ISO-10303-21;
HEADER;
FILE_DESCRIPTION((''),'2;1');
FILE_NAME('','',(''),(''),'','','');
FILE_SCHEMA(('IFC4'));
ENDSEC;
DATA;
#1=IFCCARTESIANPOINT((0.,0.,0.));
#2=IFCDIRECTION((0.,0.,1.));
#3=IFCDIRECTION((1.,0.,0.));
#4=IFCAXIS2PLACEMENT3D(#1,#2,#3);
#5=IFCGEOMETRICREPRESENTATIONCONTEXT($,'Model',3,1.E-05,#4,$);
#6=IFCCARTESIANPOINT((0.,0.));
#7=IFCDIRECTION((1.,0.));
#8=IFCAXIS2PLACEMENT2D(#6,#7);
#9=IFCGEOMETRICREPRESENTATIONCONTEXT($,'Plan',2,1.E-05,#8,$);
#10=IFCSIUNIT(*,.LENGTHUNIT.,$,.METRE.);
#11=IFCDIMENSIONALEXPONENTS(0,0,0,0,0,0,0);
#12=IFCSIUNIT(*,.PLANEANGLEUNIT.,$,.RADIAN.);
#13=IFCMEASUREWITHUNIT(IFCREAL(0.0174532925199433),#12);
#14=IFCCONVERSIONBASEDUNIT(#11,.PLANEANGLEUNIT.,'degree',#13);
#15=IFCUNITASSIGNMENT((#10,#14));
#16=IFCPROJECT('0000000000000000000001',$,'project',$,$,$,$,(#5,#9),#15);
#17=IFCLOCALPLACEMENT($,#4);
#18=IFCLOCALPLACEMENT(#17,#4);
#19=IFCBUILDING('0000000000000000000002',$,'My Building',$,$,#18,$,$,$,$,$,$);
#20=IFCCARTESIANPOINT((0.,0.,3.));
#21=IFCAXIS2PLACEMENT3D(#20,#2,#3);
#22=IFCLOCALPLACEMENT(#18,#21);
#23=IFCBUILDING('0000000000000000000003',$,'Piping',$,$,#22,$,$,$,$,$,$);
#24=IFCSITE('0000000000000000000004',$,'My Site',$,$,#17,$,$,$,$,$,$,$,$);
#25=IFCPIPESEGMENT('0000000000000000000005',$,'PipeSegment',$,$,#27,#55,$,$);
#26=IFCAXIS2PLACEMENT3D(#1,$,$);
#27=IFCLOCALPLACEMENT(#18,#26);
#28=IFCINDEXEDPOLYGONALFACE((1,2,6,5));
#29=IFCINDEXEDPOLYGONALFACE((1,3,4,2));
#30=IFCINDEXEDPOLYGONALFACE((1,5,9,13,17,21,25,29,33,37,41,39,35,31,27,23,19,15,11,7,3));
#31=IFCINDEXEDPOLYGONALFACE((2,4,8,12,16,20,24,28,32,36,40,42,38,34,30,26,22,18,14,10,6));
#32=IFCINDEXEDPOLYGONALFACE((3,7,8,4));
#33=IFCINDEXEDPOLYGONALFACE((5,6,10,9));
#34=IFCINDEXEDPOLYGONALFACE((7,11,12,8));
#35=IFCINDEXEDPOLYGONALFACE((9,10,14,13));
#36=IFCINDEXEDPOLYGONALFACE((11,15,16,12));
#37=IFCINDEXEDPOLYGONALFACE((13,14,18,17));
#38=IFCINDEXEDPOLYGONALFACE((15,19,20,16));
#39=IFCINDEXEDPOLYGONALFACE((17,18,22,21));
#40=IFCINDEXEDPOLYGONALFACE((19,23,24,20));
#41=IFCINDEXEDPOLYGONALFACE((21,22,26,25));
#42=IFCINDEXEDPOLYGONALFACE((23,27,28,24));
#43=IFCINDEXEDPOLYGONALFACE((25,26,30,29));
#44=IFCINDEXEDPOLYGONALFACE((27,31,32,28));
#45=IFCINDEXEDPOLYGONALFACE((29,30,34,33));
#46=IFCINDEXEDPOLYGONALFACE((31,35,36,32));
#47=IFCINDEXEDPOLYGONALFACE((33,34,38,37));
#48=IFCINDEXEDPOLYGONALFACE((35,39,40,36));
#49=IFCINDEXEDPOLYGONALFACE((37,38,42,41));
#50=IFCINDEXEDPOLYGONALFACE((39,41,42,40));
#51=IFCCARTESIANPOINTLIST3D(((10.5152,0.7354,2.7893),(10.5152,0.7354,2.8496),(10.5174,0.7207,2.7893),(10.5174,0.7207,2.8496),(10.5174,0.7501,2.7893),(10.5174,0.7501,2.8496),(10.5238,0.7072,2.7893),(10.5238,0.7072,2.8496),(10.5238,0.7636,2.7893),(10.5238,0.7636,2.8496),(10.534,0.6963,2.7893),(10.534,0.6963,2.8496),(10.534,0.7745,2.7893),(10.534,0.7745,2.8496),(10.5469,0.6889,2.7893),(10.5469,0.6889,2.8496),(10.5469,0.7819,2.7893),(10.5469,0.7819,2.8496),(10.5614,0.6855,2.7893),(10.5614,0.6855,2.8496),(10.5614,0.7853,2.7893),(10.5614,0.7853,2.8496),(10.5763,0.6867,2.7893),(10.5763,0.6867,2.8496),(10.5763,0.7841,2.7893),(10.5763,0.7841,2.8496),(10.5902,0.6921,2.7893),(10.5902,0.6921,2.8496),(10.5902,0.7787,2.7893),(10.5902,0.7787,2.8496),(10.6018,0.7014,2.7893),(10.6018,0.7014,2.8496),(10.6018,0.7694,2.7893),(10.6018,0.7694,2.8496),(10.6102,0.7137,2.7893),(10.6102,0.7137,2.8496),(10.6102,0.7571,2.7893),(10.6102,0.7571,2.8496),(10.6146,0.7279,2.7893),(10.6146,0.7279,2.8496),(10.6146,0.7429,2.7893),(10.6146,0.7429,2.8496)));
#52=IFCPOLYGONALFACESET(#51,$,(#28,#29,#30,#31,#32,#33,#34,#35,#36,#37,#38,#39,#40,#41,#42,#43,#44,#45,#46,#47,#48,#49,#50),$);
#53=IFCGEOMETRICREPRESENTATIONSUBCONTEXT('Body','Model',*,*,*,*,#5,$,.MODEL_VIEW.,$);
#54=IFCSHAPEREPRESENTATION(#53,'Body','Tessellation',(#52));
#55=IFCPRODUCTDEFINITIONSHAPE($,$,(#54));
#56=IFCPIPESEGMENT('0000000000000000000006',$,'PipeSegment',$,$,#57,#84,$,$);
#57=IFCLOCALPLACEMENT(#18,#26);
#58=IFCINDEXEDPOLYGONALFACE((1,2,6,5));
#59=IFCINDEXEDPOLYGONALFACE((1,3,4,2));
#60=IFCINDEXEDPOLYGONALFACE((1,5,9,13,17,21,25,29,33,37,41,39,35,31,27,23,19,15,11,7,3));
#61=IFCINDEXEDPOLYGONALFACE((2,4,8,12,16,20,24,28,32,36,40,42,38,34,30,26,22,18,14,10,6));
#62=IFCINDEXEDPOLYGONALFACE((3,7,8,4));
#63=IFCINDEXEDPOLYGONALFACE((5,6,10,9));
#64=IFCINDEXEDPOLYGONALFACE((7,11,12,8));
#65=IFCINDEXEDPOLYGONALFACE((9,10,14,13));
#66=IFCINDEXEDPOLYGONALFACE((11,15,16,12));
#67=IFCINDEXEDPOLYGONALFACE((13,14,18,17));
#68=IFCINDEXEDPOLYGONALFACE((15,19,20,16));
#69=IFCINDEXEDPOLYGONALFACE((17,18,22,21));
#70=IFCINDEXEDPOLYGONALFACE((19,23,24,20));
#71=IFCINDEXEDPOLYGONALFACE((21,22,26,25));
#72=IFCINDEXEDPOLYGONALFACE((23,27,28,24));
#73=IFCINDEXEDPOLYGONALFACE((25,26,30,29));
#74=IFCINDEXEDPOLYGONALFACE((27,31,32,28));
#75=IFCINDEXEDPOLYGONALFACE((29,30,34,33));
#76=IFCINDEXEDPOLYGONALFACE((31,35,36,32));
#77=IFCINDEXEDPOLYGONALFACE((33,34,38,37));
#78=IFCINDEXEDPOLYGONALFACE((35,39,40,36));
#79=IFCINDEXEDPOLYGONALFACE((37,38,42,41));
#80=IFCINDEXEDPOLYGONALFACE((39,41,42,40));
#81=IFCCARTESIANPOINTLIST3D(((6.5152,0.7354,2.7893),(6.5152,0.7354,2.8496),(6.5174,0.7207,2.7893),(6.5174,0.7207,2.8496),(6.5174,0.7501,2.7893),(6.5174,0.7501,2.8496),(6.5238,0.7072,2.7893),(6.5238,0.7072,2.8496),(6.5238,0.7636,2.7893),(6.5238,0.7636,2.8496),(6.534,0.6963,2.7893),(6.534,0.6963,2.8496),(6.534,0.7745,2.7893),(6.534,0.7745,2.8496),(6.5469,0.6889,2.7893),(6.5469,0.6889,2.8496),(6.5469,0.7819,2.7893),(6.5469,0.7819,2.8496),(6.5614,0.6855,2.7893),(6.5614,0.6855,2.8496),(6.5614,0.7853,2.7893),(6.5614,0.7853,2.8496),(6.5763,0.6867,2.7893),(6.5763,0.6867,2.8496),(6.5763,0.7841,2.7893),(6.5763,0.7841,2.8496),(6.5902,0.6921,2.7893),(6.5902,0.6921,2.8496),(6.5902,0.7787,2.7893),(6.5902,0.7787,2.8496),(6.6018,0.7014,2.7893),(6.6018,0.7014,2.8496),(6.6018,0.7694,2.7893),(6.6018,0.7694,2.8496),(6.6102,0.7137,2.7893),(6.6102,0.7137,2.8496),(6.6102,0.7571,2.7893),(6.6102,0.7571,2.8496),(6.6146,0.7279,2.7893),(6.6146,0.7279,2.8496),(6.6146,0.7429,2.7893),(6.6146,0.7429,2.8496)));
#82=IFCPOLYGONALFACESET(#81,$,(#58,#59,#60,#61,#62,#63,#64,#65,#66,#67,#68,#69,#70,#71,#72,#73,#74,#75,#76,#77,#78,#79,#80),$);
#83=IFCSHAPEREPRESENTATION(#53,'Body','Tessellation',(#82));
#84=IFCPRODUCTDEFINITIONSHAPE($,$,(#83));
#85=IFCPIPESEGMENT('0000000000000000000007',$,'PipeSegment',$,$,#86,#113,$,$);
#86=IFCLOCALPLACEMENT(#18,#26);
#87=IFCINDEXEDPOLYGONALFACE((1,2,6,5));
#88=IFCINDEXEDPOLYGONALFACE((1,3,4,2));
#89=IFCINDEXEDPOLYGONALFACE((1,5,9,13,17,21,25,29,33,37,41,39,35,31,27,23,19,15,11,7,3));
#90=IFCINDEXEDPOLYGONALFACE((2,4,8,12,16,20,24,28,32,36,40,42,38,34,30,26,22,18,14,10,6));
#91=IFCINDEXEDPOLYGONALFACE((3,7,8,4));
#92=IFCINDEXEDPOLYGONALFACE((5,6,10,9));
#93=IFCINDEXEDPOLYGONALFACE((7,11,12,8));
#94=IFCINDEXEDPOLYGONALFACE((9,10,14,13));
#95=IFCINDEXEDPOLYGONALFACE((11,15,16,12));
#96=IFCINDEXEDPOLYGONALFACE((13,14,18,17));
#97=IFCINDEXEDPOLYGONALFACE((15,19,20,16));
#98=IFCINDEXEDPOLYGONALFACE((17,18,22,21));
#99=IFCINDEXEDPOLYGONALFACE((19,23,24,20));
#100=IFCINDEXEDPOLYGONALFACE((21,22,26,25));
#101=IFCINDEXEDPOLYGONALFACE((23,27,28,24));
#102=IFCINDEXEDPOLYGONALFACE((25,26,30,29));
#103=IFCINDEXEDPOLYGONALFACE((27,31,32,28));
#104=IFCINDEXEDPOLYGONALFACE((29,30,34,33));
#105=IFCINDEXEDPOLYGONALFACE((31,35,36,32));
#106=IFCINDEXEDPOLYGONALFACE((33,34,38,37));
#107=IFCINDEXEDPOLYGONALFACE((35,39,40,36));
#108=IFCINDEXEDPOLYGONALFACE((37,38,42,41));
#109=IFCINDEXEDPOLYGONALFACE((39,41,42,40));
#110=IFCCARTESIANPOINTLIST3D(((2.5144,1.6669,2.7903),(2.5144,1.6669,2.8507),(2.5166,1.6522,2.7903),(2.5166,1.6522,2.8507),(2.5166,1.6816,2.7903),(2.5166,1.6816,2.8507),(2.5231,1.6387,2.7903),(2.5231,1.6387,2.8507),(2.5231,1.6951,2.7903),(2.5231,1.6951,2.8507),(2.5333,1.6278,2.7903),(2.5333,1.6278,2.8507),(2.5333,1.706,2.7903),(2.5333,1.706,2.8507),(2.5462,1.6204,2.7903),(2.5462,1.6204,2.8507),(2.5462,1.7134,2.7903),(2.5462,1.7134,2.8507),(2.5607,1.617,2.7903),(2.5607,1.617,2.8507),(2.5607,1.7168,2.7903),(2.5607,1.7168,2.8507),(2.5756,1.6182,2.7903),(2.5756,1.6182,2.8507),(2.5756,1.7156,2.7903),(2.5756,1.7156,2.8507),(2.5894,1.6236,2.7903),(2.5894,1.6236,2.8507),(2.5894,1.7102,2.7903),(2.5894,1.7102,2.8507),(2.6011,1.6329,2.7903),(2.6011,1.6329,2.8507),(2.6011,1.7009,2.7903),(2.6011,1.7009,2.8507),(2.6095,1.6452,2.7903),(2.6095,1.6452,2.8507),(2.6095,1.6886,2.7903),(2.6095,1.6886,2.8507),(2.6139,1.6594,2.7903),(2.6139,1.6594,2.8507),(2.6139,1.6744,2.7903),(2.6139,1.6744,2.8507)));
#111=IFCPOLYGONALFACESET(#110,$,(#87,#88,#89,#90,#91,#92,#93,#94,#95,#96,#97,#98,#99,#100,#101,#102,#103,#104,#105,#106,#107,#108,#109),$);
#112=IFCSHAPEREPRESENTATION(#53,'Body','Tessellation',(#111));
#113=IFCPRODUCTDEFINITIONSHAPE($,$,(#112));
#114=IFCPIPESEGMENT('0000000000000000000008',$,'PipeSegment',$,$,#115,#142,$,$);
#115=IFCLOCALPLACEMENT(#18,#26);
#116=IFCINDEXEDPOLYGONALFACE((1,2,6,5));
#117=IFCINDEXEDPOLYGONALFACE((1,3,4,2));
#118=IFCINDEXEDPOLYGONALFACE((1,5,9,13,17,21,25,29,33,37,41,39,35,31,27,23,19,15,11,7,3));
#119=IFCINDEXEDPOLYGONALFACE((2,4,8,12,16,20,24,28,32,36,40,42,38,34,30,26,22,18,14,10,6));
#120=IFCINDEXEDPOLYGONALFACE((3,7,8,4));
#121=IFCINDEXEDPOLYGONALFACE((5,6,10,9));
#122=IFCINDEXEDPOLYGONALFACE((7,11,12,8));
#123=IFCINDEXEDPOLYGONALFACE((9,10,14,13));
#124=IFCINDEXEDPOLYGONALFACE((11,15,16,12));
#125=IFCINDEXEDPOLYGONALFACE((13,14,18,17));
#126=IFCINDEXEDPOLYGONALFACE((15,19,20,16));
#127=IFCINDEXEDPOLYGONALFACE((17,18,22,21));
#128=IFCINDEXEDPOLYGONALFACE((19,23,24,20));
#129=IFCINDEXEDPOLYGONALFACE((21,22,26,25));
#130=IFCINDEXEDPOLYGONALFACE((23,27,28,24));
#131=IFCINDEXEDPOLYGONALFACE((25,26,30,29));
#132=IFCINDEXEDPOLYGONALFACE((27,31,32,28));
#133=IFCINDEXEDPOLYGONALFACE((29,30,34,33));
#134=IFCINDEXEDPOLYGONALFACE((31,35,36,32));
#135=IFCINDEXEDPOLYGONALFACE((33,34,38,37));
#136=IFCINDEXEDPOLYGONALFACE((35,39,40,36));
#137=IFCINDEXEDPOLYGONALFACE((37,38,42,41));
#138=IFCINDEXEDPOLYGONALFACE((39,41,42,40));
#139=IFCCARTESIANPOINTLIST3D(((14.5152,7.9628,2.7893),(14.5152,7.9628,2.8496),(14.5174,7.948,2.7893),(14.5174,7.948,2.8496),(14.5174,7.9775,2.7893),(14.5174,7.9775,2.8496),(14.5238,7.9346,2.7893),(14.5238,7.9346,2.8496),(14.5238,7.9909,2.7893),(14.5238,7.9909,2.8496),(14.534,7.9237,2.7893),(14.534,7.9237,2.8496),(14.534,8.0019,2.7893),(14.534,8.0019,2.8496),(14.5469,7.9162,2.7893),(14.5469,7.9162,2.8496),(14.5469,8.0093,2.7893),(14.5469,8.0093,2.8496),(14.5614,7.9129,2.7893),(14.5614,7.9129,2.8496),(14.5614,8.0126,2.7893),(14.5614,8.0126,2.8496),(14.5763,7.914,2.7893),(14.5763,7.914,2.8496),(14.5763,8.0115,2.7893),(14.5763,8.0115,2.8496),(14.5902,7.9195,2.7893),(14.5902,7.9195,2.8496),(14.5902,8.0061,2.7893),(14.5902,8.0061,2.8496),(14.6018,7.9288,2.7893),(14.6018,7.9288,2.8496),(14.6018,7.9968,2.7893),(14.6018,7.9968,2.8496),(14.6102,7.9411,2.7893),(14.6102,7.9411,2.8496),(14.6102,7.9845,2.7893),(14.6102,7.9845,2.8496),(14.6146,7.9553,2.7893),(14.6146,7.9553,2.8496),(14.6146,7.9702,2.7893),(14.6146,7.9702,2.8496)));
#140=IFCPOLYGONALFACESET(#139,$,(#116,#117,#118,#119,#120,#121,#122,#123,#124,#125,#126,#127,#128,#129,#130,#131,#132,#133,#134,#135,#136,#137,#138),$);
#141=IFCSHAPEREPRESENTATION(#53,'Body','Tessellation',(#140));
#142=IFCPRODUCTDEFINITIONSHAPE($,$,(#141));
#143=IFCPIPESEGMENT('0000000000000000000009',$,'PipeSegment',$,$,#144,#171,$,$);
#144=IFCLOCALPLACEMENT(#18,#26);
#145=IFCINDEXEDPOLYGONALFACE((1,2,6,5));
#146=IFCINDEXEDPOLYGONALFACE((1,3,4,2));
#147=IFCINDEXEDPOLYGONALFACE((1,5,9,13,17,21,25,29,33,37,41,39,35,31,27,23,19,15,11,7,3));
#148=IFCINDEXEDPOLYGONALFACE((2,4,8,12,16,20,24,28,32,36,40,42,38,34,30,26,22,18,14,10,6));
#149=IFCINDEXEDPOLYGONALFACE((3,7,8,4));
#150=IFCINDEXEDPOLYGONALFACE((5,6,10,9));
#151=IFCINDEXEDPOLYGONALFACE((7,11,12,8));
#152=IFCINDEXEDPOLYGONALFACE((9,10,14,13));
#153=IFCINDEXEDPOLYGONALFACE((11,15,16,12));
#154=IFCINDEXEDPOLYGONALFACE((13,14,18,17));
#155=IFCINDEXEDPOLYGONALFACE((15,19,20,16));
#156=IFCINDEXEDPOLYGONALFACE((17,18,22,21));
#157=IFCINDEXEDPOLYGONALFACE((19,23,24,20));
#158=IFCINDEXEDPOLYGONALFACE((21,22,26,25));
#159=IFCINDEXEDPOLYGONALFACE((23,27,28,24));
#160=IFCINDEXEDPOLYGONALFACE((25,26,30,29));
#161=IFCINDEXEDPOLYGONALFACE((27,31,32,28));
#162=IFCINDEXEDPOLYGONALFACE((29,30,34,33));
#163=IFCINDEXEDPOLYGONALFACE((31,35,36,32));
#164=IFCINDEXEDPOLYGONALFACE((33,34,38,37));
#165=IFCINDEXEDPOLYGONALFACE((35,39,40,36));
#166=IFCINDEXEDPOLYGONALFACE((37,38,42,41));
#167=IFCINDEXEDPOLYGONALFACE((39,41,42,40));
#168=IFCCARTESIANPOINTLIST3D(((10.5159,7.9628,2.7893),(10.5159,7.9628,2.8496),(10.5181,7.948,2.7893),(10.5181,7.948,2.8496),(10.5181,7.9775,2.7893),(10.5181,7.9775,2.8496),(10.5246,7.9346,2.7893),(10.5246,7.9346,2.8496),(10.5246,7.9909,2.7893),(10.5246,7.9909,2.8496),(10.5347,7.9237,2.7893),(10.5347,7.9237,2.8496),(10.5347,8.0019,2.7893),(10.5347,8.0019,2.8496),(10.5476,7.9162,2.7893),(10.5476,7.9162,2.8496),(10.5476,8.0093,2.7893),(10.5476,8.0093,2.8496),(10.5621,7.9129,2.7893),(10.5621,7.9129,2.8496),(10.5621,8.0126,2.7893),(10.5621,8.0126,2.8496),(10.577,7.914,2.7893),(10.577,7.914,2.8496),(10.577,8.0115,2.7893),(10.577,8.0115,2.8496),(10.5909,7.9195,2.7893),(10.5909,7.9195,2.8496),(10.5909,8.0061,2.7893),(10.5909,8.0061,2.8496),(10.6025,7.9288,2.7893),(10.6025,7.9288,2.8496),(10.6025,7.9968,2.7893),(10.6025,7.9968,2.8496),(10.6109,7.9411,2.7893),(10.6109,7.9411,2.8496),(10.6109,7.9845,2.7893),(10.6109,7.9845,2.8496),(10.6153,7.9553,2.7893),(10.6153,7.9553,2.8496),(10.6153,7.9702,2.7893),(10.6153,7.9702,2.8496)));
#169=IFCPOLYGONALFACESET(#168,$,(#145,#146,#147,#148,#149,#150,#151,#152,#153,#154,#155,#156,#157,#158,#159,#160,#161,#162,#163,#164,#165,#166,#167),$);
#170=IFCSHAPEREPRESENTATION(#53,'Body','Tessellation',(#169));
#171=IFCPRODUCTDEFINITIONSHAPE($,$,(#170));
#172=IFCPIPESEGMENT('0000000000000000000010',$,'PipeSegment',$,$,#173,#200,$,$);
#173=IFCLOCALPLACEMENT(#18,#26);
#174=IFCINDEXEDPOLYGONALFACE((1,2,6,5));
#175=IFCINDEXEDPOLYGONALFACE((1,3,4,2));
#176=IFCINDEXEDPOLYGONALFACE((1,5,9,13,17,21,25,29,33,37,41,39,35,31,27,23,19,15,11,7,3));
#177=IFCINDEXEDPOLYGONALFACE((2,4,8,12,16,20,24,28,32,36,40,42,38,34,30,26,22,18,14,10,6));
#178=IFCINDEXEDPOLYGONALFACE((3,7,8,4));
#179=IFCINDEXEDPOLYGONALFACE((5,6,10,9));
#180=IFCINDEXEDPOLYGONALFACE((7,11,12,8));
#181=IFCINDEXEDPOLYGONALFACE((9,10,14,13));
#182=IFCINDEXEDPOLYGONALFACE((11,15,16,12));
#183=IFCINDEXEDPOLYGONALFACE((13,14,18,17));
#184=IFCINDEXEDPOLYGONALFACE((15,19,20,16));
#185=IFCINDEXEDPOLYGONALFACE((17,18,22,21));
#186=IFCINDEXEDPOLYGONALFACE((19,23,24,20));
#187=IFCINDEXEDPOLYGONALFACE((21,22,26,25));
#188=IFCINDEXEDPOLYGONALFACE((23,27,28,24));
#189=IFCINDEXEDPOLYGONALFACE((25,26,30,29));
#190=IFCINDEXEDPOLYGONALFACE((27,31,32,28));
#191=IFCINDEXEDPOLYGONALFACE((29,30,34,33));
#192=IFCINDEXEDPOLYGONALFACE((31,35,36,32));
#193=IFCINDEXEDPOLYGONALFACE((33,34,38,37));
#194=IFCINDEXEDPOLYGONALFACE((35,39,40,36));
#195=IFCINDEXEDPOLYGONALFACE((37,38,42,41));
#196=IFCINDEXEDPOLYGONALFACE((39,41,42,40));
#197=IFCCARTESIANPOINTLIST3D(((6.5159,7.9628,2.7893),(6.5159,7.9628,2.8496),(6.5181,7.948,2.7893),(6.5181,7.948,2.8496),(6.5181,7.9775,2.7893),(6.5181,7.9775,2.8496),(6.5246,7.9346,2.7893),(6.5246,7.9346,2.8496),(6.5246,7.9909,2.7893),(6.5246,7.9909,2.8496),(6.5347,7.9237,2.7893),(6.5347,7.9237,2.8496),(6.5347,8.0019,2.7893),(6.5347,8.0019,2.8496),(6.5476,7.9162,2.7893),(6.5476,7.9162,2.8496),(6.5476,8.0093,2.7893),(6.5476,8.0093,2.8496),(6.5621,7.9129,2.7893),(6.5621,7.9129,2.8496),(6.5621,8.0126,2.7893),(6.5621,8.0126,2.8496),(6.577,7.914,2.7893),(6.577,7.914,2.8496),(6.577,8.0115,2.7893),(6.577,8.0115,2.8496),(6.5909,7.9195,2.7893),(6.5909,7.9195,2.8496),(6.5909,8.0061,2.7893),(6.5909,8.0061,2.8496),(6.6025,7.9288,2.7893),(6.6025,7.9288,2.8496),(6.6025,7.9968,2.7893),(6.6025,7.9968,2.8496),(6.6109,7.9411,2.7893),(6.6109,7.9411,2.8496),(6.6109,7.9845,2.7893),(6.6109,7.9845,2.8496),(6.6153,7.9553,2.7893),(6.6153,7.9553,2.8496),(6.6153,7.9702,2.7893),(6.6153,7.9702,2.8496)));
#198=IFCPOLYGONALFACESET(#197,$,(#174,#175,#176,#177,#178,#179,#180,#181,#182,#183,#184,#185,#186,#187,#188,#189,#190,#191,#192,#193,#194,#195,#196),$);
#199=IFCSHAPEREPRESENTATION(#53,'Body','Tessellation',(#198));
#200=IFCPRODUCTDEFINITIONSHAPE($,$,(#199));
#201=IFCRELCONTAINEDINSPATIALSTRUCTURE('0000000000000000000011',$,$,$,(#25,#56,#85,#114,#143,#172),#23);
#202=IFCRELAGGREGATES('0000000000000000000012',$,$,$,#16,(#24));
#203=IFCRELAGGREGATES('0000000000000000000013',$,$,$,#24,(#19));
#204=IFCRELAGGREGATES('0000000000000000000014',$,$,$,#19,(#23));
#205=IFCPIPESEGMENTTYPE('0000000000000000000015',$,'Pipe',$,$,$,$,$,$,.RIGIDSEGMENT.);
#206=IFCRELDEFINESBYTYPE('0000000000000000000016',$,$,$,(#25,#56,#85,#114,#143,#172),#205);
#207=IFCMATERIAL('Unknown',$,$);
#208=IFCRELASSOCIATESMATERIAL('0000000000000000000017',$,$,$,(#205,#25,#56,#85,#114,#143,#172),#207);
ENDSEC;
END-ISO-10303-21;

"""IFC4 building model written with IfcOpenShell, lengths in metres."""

from ifc_helpers import new_model, entity, si_unit, converted_unit, frame, origin_with_axes, origin_2d_with_axis, place, context, subcontext, project, spatial, circle, extrude, material, material_profile, profile_set, profile_usage, type_object, element, save


model = new_model("IFC4")

# Units and contexts
model_context = context("Model", 3, precision=1e-05, world=origin_with_axes())
plan_context = context("Plan", 2, precision=1e-05, world=origin_2d_with_axis())
body_context = subcontext(model_context, "Body", "Model", "MODEL_VIEW")
ifc_project = project(units=[si_unit("LENGTHUNIT", "METRE"), converted_unit("PLANEANGLEUNIT", "degree", entity("IfcReal", 0.0174532925199433), si_unit("PLANEANGLEUNIT", "RADIAN"), dimensions=[0, 0, 0, 0, 0, 0, 0])], contexts=[model_context, plan_context])

# Site, buildings
site_placement = place(None, origin_with_axes())
site = spatial("IfcSite", under=ifc_project, at=site_placement, Name="My Site")
building_1_placement = place(site_placement, origin_with_axes())
building_1 = spatial("IfcBuilding", under=site, at=building_1_placement, Name="My Building")
building_2_placement = place(building_1_placement, frame((0.0, 0.0, 3.0), z_axis=(0.0, 0.0, 1.0), x_axis=(1.0, 0.0, 0.0)))
building_2 = spatial("IfcBuilding", under=building_1, at=building_2_placement, Name="Piping")

# Pipe segments
ifc_material = material(Name="Unknown")
ifc_material_profile_1 = material_profile(ifc_material, circle(Radius=0.05))
ifc_profile_set_1 = profile_set([ifc_material_profile_1])
pipe_segment_type = type_object("IfcPipeSegmentType", Name="Pipe", PredefinedType="RIGIDSEGMENT", material=ifc_profile_set_1)
ifc_profile_usage_1 = profile_usage(ifc_profile_set_1, cardinal=5)
pipe_segment_1_placement = place(building_2_placement, frame((10.5652, 0.7354, -0.1504), z_axis=(0.0, 0.0, -1.0), x_axis=(-1.0, 0.0, 0.0)))
element("IfcPipeSegment", 1, at=pipe_segment_1_placement, inside=building_2, type_object=pipe_segment_type, material=ifc_profile_usage_1, Name="PipeSegment", context=body_context, shape_type="SweptSolid", body=[
    extrude(circle(Radius=0.05), origin_with_axes(), (0.0, 0.0, 1.0), 0.0604),
])
ifc_profile_usage_2 = profile_usage(ifc_profile_set_1, cardinal=5)
pipe_segment_2_placement = place(building_2_placement, frame((6.5652, 0.7354, -0.1504), z_axis=(0.0, 0.0, -1.0), x_axis=(-1.0, 0.0, 0.0)))
element("IfcPipeSegment", 2, at=pipe_segment_2_placement, inside=building_2, type_object=pipe_segment_type, material=ifc_profile_usage_2, Name="PipeSegment", context=body_context, shape_type="SweptSolid", body=[
    extrude(circle(Radius=0.05), origin_with_axes(), (0.0, 0.0, 1.0), 0.0604),
])
ifc_profile_usage_3 = profile_usage(ifc_profile_set_1, cardinal=5)
pipe_segment_3_placement = place(building_2_placement, frame((2.5644, 1.6669, -0.1493), z_axis=(0.0, 0.0, -1.0), x_axis=(-1.0, 0.0, 0.0)))
element("IfcPipeSegment", 3, at=pipe_segment_3_placement, inside=building_2, type_object=pipe_segment_type, material=ifc_profile_usage_3, Name="PipeSegment", context=body_context, shape_type="SweptSolid", body=[
    extrude(circle(Radius=0.05), origin_with_axes(), (0.0, 0.0, 1.0), 0.0604),
])
ifc_profile_usage_4 = profile_usage(ifc_profile_set_1, cardinal=5)
pipe_segment_4_placement = place(building_2_placement, frame((14.5652, 7.9628, -0.1504), z_axis=(0.0, 0.0, -1.0), x_axis=(-1.0, 0.0, 0.0)))
element("IfcPipeSegment", 4, at=pipe_segment_4_placement, inside=building_2, type_object=pipe_segment_type, material=ifc_profile_usage_4, Name="PipeSegment", context=body_context, shape_type="SweptSolid", body=[
    extrude(circle(Radius=0.05), origin_with_axes(), (0.0, 0.0, 1.0), 0.0604),
])
ifc_profile_usage_5 = profile_usage(ifc_profile_set_1, cardinal=5)
pipe_segment_5_placement = place(building_2_placement, frame((10.5659, 7.9628, -0.1504), z_axis=(0.0, 0.0, -1.0), x_axis=(-1.0, 0.0, 0.0)))
element("IfcPipeSegment", 5, at=pipe_segment_5_placement, inside=building_2, type_object=pipe_segment_type, material=ifc_profile_usage_5, Name="PipeSegment", context=body_context, shape_type="SweptSolid", body=[
    extrude(circle(Radius=0.05), origin_with_axes(), (0.0, 0.0, 1.0), 0.0604),
])
ifc_profile_usage_6 = profile_usage(ifc_profile_set_1, cardinal=5)
pipe_segment_6_placement = place(building_2_placement, frame((6.5659, 7.9628, -0.1504), z_axis=(0.0, 0.0, -1.0), x_axis=(-1.0, 0.0, 0.0)))
element("IfcPipeSegment", 6, at=pipe_segment_6_placement, inside=building_2, type_object=pipe_segment_type, material=ifc_profile_usage_6, Name="PipeSegment", context=body_context, shape_type="SweptSolid", body=[
    extrude(circle(Radius=0.05), origin_with_axes(), (0.0, 0.0, 1.0), 0.0604),
])

save(model, "model.ifc")
